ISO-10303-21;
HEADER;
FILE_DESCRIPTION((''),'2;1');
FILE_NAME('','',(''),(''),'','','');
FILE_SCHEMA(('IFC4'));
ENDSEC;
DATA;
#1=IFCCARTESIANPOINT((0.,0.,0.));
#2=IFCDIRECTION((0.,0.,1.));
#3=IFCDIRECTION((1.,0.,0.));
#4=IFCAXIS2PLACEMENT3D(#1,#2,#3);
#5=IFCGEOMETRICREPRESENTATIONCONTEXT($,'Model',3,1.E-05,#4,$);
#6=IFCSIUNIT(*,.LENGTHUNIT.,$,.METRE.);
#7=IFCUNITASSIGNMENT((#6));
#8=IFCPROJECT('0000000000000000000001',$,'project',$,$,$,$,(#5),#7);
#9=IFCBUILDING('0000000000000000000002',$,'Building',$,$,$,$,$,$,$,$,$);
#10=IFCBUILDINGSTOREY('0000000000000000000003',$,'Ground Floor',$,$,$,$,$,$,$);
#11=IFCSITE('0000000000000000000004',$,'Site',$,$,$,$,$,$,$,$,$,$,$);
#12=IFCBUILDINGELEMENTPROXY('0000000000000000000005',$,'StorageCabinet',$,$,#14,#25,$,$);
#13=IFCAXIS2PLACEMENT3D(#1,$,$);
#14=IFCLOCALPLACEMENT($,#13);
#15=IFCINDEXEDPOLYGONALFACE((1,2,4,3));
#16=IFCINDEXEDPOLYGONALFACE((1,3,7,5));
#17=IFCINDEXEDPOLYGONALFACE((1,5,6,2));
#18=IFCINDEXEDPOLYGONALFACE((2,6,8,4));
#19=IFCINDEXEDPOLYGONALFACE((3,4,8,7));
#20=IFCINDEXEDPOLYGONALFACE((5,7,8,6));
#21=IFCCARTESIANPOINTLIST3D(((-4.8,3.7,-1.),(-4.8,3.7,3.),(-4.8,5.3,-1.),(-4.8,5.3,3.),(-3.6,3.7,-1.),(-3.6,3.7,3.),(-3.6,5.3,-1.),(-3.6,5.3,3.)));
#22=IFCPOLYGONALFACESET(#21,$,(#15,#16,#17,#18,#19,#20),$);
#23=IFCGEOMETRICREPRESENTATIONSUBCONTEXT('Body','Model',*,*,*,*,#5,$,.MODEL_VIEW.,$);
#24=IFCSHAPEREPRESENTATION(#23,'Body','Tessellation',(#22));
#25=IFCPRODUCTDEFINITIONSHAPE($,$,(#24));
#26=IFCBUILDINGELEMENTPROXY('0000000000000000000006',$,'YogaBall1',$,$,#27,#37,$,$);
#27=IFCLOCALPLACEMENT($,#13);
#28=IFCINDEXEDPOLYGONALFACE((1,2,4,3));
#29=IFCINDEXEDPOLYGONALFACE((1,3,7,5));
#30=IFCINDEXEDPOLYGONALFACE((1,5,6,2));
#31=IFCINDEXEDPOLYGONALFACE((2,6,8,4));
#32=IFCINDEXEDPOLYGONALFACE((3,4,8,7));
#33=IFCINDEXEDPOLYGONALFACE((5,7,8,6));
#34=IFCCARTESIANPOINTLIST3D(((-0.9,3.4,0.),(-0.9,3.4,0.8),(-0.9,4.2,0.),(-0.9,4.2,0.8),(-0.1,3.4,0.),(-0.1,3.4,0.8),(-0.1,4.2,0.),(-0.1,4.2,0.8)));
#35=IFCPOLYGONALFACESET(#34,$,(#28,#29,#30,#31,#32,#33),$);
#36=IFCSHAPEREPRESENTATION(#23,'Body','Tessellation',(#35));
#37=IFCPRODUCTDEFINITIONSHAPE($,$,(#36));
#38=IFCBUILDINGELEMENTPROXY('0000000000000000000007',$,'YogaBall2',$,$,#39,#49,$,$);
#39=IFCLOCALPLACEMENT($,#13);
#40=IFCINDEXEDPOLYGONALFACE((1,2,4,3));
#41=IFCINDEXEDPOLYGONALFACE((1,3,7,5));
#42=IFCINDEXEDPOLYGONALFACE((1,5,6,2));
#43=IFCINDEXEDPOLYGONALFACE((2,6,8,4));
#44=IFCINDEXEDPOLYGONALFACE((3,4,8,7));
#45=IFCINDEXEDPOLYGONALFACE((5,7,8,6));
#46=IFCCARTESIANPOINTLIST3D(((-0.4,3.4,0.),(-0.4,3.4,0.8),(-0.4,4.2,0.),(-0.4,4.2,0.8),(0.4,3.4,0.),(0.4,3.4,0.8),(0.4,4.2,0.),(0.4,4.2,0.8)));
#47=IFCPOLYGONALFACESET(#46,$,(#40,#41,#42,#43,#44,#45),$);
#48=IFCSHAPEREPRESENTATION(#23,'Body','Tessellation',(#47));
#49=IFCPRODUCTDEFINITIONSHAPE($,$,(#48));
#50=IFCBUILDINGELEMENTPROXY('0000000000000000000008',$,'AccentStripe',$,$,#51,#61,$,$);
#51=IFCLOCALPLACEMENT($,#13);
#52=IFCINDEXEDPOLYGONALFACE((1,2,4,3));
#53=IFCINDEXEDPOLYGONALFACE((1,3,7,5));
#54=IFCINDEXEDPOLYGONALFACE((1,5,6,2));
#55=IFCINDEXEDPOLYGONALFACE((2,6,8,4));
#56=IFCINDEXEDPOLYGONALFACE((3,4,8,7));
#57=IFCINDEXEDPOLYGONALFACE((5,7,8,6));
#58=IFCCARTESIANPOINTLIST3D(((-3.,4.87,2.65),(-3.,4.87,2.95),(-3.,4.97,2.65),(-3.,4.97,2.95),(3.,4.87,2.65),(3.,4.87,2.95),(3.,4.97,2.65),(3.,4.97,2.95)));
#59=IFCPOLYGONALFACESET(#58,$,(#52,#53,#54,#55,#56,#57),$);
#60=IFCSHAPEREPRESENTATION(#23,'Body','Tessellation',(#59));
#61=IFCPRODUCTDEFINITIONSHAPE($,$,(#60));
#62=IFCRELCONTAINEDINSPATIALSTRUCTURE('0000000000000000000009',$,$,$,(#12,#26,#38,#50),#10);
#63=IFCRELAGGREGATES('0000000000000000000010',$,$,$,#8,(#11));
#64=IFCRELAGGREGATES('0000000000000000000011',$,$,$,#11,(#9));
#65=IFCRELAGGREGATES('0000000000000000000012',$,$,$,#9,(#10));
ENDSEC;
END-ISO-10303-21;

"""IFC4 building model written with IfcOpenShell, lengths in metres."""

from ifc_helpers import new_model, si_unit, frame, origin_with_axes, origin_2d, place, context, subcontext, project, spatial, rectangle, extrude, element, save


model = new_model("IFC4")

# Units and contexts
model_context = context("Model", 3, precision=1e-05, world=origin_with_axes())
body_context = subcontext(model_context, "Body", "Model", "MODEL_VIEW")
ifc_project = project(units=[si_unit("LENGTHUNIT", "METRE")], contexts=[model_context])

# Site, building, storey
site = spatial("IfcSite", under=ifc_project, Name="Site")
building = spatial("IfcBuilding", under=site, Name="Building")
storey = spatial("IfcBuildingStorey", under=building, Name="Ground Floor")

# Building element proxies
proxy_1_placement = place(None, frame((-4.2, 4.5, 1.0), z_axis=(0.0, 0.0, 1.0), x_axis=(1.0, 0.0, 0.0)))
element("IfcBuildingElementProxy", 1, at=proxy_1_placement, inside=storey, Name="StorageCabinet", context=body_context, shape_type="SweptSolid", body=[
    extrude(rectangle(XDim=1.2, YDim=1.6, at=origin_2d()), frame((0.0, 0.0, -2.0)), (0.0, 0.0, 1.0), 4.0),
])
for number, where, z_axis, x_axis, name in (
    (2, (-0.5, 3.8, 0.4), (0.0, 0.0, 1.0), (1.0, 0.0, 0.0), "YogaBall1"),
    (3, (0.0, 3.8, 0.4), (0.0, 0.0, 1.0), (1.0, 0.0, 0.0), "YogaBall2"),
):
    element("IfcBuildingElementProxy", number, at=place(None, frame(where, z_axis=z_axis, x_axis=x_axis)), inside=storey, Name=name, context=body_context, shape_type="SweptSolid", body=[
        extrude(rectangle(XDim=0.8, YDim=0.8, at=origin_2d()), frame((0.0, 0.0, -0.4)), (0.0, 0.0, 1.0), 0.8),
    ])
proxy_2_placement = place(None, frame((0.0, 4.92, 2.8), z_axis=(0.0, 0.0, 1.0), x_axis=(1.0, 0.0, 0.0)))
element("IfcBuildingElementProxy", 4, at=proxy_2_placement, inside=storey, Name="AccentStripe", context=body_context, shape_type="SweptSolid", body=[
    extrude(rectangle(XDim=6.0, YDim=0.1, at=origin_2d()), frame((0.0, 0.0, -0.15)), (0.0, 0.0, 1.0), 0.3),
])

save(model, "model.ifc")
